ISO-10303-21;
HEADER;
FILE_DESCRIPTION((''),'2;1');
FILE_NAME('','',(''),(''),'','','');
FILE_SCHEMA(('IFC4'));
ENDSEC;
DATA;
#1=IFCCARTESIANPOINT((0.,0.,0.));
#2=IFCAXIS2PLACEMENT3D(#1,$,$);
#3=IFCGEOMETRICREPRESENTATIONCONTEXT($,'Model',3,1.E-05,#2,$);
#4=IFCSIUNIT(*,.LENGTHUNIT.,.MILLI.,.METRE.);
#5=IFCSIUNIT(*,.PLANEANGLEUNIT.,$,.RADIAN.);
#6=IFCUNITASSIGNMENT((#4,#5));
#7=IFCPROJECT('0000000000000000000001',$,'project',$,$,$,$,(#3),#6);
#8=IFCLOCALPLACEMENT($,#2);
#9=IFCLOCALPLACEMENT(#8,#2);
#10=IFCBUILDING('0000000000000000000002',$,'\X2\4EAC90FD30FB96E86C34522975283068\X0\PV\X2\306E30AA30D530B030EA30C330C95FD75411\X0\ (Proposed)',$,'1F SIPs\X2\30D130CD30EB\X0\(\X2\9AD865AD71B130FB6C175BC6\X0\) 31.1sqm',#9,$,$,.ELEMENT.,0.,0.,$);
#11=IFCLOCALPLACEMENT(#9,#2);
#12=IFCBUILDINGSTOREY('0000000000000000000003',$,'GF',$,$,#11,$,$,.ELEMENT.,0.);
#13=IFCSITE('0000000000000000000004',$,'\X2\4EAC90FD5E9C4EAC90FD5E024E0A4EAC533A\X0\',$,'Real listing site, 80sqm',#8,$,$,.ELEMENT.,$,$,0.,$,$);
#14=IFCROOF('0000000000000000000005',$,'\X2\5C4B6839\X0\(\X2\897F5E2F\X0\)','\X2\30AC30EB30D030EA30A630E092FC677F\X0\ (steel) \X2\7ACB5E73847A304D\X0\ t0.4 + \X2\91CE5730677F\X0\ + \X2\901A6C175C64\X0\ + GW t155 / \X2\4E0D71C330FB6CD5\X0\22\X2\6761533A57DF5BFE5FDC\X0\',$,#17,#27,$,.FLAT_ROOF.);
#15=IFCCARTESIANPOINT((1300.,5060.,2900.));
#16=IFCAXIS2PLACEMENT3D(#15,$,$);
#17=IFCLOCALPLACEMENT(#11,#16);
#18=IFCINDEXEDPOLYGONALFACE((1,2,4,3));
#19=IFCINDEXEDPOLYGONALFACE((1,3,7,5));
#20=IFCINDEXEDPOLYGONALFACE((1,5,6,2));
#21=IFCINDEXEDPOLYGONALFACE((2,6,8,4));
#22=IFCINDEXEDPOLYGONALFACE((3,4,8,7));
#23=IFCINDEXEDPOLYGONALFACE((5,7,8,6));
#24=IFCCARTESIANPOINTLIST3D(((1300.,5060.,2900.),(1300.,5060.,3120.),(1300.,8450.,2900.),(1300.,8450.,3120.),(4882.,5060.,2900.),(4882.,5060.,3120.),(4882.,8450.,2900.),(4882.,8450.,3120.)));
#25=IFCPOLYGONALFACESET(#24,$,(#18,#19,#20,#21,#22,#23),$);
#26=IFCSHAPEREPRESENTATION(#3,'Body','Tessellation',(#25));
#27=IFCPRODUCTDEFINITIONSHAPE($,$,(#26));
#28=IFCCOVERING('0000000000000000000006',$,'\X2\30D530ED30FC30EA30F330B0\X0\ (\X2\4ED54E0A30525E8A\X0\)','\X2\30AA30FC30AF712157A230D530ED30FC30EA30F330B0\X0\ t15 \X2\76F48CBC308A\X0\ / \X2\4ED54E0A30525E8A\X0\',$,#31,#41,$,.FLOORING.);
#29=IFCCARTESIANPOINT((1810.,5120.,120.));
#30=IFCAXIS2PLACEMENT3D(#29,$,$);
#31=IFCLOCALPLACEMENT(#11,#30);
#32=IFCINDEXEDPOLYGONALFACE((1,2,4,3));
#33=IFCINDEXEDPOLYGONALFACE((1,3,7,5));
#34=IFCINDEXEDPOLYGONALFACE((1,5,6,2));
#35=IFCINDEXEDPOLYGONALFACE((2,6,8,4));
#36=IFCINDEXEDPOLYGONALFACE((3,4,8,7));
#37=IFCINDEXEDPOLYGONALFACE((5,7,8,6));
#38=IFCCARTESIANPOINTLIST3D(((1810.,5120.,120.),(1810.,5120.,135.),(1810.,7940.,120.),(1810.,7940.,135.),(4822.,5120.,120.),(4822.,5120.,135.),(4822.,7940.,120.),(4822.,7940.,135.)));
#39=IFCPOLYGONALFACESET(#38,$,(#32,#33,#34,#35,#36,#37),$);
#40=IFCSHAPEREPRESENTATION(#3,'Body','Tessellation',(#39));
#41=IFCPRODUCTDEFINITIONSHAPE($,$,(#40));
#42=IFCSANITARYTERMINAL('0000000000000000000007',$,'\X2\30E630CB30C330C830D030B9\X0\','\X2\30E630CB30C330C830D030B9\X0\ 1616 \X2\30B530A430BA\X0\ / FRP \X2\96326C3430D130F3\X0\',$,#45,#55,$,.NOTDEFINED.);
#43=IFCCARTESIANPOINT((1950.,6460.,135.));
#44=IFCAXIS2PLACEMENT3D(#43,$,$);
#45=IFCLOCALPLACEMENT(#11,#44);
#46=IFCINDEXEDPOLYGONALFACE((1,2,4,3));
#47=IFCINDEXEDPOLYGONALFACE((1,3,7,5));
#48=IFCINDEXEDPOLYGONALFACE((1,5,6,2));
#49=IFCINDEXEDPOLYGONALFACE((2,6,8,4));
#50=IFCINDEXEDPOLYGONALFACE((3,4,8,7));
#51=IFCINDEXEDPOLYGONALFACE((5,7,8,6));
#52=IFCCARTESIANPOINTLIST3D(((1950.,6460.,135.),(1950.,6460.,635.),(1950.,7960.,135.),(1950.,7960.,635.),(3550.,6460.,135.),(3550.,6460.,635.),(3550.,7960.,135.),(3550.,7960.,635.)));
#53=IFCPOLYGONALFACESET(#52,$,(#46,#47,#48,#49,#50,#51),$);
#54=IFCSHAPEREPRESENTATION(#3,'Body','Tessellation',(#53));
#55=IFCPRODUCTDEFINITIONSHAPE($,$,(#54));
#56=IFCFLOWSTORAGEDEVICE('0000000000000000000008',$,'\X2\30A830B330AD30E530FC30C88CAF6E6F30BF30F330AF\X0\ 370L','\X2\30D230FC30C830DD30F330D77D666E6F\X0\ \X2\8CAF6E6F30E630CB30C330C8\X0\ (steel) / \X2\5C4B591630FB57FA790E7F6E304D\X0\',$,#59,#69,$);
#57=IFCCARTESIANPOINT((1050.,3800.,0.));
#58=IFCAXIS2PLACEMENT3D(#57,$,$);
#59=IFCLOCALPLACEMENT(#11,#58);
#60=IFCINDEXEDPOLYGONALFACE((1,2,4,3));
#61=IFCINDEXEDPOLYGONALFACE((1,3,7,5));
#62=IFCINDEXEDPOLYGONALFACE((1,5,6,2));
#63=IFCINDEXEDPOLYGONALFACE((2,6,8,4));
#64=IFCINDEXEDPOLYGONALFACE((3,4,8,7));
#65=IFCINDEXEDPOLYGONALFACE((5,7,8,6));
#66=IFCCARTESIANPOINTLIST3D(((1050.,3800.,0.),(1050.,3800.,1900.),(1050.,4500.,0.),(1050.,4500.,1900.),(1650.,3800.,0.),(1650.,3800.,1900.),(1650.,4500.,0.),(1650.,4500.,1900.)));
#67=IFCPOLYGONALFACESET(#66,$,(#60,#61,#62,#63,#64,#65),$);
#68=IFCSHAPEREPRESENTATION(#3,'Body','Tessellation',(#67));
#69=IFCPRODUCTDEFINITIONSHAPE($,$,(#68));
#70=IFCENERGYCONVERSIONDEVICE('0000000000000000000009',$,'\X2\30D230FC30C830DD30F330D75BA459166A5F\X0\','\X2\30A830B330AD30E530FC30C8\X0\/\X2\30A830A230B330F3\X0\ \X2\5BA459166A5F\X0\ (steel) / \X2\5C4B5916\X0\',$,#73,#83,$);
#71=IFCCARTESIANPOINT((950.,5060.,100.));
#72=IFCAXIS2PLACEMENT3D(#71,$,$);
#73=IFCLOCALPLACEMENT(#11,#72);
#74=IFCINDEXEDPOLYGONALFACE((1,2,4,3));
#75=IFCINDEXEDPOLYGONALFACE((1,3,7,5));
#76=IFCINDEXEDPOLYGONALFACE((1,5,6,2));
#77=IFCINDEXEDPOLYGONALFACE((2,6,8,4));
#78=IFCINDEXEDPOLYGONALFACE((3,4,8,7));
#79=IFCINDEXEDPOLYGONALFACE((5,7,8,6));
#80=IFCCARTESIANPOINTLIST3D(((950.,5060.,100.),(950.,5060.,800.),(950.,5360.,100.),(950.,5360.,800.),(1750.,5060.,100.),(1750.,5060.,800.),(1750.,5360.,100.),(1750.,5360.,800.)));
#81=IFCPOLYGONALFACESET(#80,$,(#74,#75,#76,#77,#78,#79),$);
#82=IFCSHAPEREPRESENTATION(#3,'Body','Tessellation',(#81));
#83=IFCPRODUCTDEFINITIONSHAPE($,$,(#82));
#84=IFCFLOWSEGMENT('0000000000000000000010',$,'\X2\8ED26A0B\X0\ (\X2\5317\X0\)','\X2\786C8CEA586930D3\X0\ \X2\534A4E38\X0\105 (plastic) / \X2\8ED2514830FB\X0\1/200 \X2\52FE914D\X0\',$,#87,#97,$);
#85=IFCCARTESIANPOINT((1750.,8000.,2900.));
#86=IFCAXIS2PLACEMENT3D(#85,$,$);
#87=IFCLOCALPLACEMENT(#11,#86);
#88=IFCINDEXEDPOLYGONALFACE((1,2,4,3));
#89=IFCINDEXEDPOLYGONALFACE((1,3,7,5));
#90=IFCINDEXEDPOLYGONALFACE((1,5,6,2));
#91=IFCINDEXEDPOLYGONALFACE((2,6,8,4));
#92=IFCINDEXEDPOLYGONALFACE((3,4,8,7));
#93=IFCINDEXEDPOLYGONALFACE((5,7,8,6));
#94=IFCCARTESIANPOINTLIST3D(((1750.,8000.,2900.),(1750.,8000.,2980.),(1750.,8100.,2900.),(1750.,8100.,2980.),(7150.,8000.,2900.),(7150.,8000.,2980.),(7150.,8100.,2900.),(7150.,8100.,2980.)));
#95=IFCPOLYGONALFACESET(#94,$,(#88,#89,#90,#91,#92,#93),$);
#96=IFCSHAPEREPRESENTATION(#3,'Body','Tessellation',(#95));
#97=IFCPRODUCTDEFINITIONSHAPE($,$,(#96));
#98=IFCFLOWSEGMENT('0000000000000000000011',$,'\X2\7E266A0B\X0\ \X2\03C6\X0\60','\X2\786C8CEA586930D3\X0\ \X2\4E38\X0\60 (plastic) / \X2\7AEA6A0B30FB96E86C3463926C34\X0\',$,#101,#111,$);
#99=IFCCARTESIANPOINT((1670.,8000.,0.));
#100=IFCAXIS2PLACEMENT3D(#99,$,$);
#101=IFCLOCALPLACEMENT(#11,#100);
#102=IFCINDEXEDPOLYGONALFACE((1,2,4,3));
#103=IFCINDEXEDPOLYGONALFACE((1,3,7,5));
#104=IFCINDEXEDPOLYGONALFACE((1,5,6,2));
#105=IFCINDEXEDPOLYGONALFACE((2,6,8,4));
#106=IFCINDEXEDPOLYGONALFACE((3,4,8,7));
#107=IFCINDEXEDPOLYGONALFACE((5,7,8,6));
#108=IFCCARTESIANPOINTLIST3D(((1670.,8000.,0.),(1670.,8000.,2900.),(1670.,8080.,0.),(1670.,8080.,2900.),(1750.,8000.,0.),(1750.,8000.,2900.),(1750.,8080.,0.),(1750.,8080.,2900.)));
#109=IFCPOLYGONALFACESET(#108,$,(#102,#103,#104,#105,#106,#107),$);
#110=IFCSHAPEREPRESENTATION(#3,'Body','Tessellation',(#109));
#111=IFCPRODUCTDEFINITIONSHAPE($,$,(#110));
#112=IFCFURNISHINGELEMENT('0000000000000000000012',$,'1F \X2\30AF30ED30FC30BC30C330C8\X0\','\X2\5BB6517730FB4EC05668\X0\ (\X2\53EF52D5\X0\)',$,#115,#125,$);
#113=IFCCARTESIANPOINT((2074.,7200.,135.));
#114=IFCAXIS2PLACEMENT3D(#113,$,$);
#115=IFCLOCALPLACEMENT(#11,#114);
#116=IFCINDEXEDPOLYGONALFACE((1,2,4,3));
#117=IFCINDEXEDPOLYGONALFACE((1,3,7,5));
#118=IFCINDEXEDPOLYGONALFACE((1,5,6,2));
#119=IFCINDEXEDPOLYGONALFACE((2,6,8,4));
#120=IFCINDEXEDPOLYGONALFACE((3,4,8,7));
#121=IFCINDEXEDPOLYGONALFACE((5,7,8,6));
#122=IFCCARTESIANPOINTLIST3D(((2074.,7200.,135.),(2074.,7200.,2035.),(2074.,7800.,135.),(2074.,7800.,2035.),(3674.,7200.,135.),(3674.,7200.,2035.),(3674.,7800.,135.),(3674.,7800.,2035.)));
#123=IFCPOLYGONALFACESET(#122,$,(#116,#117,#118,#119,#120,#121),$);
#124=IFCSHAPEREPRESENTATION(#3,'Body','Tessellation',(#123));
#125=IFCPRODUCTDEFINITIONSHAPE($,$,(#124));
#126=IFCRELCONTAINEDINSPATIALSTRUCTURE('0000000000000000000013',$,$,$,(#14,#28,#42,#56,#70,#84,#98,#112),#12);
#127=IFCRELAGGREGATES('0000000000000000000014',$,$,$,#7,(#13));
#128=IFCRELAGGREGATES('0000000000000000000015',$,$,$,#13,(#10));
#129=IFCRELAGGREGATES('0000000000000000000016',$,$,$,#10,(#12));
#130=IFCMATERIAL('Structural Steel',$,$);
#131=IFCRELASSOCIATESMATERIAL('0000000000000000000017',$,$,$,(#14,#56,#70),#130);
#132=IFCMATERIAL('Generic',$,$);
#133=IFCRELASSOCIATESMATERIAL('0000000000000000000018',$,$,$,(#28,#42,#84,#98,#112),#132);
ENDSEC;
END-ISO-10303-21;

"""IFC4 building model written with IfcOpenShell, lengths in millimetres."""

from ifc_helpers import new_model, si_unit, frame, frame_2d, origin, place, context, project, spatial, rectangle, extrude, material, element, save


model = new_model("IFC4")

# Units and contexts
model_context = context("Model", 3, precision=1e-05, world=origin())
ifc_project = project(units=[si_unit("LENGTHUNIT", "METRE", prefix="MILLI"), si_unit("PLANEANGLEUNIT", "RADIAN")], contexts=[model_context])

# Site, building, storey
site_placement = place(None, origin())
site = spatial("IfcSite", under=ifc_project, at=site_placement, Name="京都府京都市上京区", ObjectType="Real listing site, 80sqm", CompositionType="ELEMENT", RefElevation=0.0)
building_placement = place(site_placement, origin())
building = spatial("IfcBuilding", under=site, at=building_placement, Name="京都・雨水利用とPVのオフグリッド志向 (Proposed)", ObjectType="1F SIPsパネル(高断熱・気密) 31.1sqm", CompositionType="ELEMENT", ElevationOfRefHeight=0.0, ElevationOfTerrain=0.0)
storey_placement = place(building_placement, origin())
storey = spatial("IfcBuildingStorey", under=building, at=storey_placement, Name="GF", CompositionType="ELEMENT", Elevation=0.0)

# Roof
ifc_material_1 = material(Name="Structural Steel")
roof_placement = place(storey_placement, frame((1300.0, 5060.0, 2900.0)))
element("IfcRoof", 1, at=roof_placement, inside=storey, material=ifc_material_1, Name="屋根(西帯)", Description="ガルバリウム鋼板 (steel) 立平葺き t0.4 + 野地板 + 通気層 + GW t155 / 不燃・法22条区域対応", PredefinedType="FLAT_ROOF", context=model_context, shape_type="SweptSolid", body=[
    extrude(rectangle(XDim=3582.0, YDim=3390.0, at=frame_2d((1791.0, 1695.0))), frame((1300.0, 5060.0, 2900.0)), (0.0, 0.0, 1.0), 220.0),
])

# Covering
ifc_material_2 = material(Name="Generic")
covering_placement = place(storey_placement, frame((1810.0, 5120.0, 120.0)))
element("IfcCovering", 2, at=covering_placement, inside=storey, material=ifc_material_2, Name="フローリング (仕上げ床)", Description="オーク無垢フローリング t15 直貼り / 仕上げ床", PredefinedType="FLOORING", context=model_context, shape_type="SweptSolid", body=[
    extrude(rectangle(XDim=3012.0, YDim=2820.0, at=frame_2d((1506.0, 1410.0))), frame((1810.0, 5120.0, 120.0)), (0.0, 0.0, 1.0), 15.0),
])

# Sanitary terminal
sanitary_terminal_placement = place(storey_placement, frame((1950.0, 6460.0, 135.0)))
element("IfcSanitaryTerminal", 3, at=sanitary_terminal_placement, inside=storey, material=ifc_material_2, Name="ユニットバス", Description="ユニットバス 1616 サイズ / FRP 防水パン", PredefinedType="NOTDEFINED", context=model_context, shape_type="SweptSolid", body=[
    extrude(rectangle(XDim=1600.0, YDim=1500.0, at=frame_2d((800.0, 750.0))), frame((1950.0, 6460.0, 135.0)), (0.0, 0.0, 1.0), 500.0),
])

# Flow storage device
flow_storage_device_placement = place(storey_placement, frame((1050.0, 3800.0, 0.0)))
element("IfcFlowStorageDevice", 4, at=flow_storage_device_placement, inside=storey, material=ifc_material_1, Name="エコキュート貯湯タンク 370L", Description="ヒートポンプ給湯 貯湯ユニット (steel) / 屋外・基礎置き", context=model_context, shape_type="SweptSolid", body=[
    extrude(rectangle(XDim=600.0, YDim=700.0, at=frame_2d((300.0, 350.0))), frame((1050.0, 3800.0, 0.0)), (0.0, 0.0, 1.0), 1900.0),
])

# Energy conversion device
energy_conversion_device_placement = place(storey_placement, frame((950.0, 5060.0, 100.0)))
element("IfcEnergyConversionDevice", 5, at=energy_conversion_device_placement, inside=storey, material=ifc_material_1, Name="ヒートポンプ室外機", Description="エコキュート/エアコン 室外機 (steel) / 屋外", context=model_context, shape_type="SweptSolid", body=[
    extrude(rectangle(XDim=800.0, YDim=300.0, at=frame_2d((400.0, 150.0))), frame((950.0, 5060.0, 100.0)), (0.0, 0.0, 1.0), 700.0),
])

# Flow segments
flow_segment_1_placement = place(storey_placement, frame((1750.0, 8000.0, 2900.0)))
element("IfcFlowSegment", 6, at=flow_segment_1_placement, inside=storey, material=ifc_material_2, Name="軒樋 (北)", Description="硬質塩ビ 半丸105 (plastic) / 軒先・1/200 勾配", context=model_context, shape_type="SweptSolid", body=[
    extrude(rectangle(XDim=5400.0, YDim=100.0, at=frame_2d((2700.0, 50.0))), frame((1750.0, 8000.0, 2900.0)), (0.0, 0.0, 1.0), 80.0),
])
flow_segment_2_placement = place(storey_placement, frame((1670.0, 8000.0, 0.0)))
element("IfcFlowSegment", 7, at=flow_segment_2_placement, inside=storey, material=ifc_material_2, Name="縦樋 φ60", Description="硬質塩ビ 丸60 (plastic) / 竪樋・雨水排水", context=model_context, shape_type="SweptSolid", body=[
    extrude(rectangle(XDim=80.0, YDim=80.0, at=frame_2d((40.0, 40.0))), frame((1670.0, 8000.0, 0.0)), (0.0, 0.0, 1.0), 2900.0),
])

# Furnishing element
furnishing_placement = place(storey_placement, frame((2074.0, 7200.0, 135.0)))
element("IfcFurnishingElement", 8, at=furnishing_placement, inside=storey, material=ifc_material_2, Name="1F クローゼット", Description="家具・什器 (可動)", context=model_context, shape_type="SweptSolid", body=[
    extrude(rectangle(XDim=1600.0, YDim=600.0, at=frame_2d((800.0, 300.0))), frame((2074.0, 7200.0, 135.0)), (0.0, 0.0, 1.0), 1900.0),
])

save(model, "model.ifc")
